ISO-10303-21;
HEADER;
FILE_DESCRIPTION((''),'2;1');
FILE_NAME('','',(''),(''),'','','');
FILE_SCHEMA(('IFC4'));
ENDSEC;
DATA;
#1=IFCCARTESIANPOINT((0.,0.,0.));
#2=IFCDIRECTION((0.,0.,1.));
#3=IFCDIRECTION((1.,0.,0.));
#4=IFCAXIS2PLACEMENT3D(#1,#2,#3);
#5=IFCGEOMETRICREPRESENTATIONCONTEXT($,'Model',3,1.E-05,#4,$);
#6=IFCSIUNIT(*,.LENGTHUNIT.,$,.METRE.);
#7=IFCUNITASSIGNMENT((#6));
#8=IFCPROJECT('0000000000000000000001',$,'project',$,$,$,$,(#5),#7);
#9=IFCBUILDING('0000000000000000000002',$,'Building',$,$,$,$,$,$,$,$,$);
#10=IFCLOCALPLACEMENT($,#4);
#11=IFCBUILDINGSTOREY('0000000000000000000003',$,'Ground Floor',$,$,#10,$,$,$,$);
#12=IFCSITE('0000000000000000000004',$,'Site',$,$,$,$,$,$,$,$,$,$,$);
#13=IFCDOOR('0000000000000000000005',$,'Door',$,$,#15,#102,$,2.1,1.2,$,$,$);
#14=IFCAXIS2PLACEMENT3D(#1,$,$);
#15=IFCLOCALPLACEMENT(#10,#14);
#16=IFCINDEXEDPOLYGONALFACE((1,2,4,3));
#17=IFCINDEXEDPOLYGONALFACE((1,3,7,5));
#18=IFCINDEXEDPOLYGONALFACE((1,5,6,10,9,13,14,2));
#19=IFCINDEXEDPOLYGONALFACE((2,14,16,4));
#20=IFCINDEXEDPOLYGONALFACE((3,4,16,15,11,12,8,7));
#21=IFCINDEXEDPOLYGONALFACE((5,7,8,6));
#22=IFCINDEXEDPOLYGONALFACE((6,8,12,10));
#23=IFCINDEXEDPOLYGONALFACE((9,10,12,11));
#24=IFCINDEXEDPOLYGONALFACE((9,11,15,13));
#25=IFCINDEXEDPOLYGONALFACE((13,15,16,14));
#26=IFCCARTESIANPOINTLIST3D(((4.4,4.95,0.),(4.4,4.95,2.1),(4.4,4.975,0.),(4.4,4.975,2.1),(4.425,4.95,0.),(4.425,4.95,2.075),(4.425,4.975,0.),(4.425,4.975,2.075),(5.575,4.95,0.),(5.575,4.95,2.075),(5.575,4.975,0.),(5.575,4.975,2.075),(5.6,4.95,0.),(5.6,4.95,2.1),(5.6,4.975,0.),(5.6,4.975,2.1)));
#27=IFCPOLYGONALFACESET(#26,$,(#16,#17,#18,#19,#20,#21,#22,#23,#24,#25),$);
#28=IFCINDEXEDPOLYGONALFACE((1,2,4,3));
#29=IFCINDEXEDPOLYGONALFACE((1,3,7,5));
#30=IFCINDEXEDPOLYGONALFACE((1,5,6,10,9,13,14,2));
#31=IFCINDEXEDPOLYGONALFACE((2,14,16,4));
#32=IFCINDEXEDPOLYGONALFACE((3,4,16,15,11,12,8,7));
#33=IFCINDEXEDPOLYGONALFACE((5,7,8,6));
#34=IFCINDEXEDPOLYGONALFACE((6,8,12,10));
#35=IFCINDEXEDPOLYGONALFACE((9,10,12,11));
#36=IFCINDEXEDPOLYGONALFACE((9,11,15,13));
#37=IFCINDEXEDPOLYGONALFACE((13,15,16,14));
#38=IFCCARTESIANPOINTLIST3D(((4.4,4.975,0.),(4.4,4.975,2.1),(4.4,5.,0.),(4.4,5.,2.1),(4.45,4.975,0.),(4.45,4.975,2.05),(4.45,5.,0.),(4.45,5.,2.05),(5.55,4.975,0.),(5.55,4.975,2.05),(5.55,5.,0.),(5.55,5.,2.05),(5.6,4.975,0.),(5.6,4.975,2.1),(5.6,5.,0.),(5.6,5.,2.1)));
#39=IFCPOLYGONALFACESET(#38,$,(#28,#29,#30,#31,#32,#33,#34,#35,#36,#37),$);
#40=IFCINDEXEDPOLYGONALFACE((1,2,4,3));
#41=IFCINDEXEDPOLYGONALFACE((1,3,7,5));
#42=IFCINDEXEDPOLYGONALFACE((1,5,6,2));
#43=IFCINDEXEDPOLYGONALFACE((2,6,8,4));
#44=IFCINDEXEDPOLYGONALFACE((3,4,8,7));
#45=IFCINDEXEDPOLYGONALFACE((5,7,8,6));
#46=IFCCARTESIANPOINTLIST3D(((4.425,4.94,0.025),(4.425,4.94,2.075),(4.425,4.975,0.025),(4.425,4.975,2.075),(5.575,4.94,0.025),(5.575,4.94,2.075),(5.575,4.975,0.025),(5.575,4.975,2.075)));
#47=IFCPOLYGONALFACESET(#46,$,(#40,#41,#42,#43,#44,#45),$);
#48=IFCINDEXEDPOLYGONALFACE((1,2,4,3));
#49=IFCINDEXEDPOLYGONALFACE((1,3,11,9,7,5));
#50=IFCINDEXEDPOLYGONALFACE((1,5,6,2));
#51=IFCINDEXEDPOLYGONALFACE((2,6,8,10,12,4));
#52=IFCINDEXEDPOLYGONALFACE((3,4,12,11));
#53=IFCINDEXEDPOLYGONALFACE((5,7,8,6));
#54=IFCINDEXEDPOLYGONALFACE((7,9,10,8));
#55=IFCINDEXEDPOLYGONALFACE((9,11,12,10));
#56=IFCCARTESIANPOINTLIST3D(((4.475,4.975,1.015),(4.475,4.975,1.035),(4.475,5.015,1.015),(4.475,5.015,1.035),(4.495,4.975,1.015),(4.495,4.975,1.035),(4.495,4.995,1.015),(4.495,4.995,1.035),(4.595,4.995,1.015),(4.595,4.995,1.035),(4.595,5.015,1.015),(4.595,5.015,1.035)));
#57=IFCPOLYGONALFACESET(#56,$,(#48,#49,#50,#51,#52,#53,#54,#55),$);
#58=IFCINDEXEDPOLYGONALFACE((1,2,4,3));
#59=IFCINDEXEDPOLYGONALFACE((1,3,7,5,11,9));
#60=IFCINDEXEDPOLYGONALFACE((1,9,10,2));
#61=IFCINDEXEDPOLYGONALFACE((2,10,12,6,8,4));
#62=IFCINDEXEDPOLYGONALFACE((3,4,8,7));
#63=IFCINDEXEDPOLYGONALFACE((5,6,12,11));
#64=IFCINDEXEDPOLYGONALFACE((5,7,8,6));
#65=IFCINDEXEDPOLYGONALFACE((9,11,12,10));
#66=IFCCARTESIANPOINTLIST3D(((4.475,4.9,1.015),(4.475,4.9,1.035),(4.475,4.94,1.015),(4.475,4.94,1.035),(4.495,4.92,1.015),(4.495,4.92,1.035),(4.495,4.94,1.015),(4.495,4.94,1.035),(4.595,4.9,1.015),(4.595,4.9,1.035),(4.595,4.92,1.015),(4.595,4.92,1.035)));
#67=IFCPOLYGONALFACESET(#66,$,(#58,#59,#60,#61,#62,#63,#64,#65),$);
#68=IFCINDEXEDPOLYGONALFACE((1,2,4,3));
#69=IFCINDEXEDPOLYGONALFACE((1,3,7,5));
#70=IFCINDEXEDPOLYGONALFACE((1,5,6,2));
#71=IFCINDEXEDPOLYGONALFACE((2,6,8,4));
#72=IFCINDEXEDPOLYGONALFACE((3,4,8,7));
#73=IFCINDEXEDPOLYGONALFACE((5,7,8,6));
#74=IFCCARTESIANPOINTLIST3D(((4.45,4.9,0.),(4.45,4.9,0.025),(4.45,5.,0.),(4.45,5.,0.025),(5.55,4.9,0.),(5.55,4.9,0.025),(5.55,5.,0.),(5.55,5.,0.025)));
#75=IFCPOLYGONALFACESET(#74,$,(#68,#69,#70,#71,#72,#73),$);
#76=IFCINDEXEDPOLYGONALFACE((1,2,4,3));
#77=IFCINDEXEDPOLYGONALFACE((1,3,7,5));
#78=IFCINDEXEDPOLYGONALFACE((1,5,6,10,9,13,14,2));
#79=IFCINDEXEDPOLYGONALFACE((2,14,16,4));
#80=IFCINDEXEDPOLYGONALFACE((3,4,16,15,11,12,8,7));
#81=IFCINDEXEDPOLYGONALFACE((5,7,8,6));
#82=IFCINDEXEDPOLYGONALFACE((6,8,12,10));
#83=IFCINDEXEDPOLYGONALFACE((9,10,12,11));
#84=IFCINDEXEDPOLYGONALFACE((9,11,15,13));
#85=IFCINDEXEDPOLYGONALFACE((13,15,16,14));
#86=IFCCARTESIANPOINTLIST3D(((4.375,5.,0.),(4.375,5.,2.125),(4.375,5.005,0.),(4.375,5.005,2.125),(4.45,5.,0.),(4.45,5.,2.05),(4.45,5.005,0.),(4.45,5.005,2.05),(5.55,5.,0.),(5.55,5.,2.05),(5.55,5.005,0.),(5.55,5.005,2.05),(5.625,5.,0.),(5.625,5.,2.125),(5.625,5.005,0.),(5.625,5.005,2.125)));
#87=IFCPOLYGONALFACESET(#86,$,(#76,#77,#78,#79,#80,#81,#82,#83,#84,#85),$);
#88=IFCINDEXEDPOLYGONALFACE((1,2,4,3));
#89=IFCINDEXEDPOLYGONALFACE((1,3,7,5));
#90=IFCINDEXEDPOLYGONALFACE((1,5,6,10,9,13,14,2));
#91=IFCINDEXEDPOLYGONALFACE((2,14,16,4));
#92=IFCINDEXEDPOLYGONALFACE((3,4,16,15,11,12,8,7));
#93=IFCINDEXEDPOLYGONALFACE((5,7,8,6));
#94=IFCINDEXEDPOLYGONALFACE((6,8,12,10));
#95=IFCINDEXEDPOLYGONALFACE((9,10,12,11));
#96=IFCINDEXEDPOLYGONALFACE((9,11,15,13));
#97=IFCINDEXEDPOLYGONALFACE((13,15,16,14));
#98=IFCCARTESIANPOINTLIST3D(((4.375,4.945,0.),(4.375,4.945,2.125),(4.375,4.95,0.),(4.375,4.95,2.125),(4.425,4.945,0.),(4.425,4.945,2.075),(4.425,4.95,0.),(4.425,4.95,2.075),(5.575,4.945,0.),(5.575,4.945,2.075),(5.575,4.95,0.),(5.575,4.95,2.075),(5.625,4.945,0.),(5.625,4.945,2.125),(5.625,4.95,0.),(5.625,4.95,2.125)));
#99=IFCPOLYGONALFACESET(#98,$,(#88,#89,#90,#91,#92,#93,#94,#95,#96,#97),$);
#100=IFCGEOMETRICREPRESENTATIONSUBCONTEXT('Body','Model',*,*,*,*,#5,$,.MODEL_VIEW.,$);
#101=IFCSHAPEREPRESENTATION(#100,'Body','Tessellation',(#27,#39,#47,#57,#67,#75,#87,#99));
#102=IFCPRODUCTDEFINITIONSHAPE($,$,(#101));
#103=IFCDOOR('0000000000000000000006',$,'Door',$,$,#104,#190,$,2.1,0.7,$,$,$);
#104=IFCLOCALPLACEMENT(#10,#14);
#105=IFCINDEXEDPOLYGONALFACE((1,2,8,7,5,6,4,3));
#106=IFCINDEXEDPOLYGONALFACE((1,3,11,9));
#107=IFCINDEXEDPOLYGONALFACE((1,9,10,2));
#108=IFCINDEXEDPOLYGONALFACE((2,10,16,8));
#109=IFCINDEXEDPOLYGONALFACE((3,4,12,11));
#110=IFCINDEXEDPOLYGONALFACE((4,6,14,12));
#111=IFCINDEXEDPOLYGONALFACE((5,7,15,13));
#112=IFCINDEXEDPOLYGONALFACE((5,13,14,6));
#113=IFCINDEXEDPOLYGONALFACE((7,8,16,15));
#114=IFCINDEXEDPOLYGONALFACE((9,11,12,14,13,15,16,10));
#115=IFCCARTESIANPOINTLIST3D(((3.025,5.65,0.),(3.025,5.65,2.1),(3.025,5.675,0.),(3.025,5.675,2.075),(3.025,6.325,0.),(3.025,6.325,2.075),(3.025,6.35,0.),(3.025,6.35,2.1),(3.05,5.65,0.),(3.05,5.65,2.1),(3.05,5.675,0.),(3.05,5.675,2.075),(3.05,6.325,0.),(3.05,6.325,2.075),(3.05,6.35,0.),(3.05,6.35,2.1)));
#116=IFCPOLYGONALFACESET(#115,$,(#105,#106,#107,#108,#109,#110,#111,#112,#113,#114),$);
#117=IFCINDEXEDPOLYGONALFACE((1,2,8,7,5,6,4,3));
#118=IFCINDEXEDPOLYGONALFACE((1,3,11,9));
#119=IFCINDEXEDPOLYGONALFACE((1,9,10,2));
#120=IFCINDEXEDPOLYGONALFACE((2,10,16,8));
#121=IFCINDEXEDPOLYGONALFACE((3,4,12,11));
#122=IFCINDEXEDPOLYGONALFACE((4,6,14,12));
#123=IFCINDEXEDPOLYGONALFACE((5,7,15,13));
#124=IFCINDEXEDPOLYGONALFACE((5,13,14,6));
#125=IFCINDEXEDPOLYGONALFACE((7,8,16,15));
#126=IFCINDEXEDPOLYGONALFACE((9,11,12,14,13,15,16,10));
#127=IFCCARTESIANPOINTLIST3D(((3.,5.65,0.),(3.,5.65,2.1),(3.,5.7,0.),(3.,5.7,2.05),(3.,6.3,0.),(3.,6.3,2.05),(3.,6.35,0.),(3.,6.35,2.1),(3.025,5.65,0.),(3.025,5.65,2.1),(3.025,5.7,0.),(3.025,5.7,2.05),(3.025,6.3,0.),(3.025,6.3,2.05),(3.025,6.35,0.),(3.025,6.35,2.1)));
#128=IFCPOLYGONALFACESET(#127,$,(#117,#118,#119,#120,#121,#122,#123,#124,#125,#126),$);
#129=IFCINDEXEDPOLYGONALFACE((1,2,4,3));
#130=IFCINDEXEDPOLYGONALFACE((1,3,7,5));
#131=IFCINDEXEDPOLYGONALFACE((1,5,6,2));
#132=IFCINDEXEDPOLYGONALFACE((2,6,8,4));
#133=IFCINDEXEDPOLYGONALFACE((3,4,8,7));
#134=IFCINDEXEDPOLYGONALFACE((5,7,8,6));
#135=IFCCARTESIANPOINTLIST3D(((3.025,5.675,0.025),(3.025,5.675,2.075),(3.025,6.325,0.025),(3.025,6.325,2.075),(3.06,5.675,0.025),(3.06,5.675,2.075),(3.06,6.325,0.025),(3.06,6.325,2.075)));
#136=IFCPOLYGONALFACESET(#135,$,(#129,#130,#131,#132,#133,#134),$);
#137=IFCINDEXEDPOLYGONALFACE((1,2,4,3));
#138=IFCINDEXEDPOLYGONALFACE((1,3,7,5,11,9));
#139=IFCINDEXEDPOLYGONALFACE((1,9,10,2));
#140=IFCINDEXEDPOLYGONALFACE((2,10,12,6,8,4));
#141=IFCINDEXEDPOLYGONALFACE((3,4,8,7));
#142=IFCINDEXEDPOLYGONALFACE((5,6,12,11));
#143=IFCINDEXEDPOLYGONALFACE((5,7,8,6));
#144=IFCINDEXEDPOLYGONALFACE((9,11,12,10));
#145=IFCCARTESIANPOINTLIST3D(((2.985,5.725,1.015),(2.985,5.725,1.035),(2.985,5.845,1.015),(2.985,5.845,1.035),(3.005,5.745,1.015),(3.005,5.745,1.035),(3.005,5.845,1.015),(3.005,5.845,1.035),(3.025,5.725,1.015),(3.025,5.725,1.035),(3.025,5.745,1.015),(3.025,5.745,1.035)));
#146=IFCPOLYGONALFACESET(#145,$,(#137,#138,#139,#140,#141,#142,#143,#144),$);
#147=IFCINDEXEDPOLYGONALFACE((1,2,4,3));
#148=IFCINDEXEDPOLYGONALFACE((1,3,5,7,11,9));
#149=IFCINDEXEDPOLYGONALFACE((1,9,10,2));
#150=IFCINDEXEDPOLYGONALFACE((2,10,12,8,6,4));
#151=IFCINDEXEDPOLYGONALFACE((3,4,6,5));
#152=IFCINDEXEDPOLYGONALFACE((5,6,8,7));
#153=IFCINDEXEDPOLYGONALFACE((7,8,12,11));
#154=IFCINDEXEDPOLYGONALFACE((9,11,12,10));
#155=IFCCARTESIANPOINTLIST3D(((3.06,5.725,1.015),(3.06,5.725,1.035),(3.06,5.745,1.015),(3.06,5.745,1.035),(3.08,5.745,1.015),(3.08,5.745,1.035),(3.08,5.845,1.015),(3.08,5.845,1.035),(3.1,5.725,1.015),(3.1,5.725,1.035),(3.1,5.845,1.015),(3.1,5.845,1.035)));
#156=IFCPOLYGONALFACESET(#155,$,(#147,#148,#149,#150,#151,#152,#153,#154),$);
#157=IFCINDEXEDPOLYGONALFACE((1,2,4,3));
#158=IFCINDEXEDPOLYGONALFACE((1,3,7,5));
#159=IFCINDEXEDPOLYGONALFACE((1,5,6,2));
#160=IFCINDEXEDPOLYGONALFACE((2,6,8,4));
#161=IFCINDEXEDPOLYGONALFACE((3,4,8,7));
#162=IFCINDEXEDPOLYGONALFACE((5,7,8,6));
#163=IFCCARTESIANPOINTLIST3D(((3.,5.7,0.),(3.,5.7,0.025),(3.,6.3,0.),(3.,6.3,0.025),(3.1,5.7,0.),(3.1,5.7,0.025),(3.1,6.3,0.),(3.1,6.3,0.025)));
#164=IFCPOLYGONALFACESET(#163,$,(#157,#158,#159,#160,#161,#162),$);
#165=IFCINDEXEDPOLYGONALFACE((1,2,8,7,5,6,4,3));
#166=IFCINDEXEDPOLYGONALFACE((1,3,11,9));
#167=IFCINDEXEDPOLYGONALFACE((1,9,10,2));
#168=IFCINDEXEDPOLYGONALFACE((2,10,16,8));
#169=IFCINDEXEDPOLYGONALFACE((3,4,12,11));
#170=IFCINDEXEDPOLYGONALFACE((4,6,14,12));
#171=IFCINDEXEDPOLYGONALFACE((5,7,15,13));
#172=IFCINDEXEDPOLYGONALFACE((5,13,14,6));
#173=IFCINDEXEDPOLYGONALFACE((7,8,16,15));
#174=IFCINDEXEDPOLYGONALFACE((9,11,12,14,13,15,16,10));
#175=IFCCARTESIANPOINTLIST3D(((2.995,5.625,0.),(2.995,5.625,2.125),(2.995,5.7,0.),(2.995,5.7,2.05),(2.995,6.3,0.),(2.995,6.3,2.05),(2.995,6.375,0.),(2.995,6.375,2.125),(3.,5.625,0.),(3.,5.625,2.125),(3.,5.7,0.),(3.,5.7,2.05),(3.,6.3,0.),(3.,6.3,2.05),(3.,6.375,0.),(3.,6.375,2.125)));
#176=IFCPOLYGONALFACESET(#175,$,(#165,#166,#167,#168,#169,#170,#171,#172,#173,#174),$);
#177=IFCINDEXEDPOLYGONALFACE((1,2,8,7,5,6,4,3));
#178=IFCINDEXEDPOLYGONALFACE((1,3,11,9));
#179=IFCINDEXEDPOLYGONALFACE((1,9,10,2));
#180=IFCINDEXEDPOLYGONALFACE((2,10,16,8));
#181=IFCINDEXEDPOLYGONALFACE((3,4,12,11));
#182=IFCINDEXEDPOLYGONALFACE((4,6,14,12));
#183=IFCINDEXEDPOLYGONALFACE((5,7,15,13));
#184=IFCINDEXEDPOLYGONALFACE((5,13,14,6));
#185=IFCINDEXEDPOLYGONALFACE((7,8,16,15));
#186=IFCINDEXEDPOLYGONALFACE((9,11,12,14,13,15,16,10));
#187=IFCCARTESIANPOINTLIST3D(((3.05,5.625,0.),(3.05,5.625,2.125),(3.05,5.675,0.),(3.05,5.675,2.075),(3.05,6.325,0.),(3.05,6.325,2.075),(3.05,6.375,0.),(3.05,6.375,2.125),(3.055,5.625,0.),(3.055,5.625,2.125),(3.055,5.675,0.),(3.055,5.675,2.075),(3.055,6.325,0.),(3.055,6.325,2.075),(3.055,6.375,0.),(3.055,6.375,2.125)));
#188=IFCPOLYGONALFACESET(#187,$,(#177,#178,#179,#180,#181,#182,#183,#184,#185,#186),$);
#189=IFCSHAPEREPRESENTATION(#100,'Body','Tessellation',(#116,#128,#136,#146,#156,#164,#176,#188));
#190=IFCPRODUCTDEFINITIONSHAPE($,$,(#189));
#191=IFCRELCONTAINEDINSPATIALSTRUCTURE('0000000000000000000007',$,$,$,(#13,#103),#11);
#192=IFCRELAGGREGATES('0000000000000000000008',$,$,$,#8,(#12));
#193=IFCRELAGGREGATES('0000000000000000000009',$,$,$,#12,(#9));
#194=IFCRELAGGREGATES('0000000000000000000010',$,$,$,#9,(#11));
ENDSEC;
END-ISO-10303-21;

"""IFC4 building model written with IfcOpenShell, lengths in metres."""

from ifc_helpers import new_model, si_unit, frame, origin_with_axes, place, context, subcontext, project, spatial, line, indexed_curve, outline, extrude, element, save


model = new_model("IFC4")

# Units and contexts
model_context = context("Model", 3, precision=1e-05, world=origin_with_axes())
body_context = subcontext(model_context, "Body", "Model", "MODEL_VIEW")
ifc_project = project(units=[si_unit("LENGTHUNIT", "METRE")], contexts=[model_context])

# Site, building, storey
site = spatial("IfcSite", under=ifc_project, Name="Site")
building = spatial("IfcBuilding", under=site, Name="Building")
storey_placement = place(None, origin_with_axes())
storey = spatial("IfcBuildingStorey", under=building, at=storey_placement, Name="Ground Floor")

# Doors
door_1_placement = place(storey_placement, frame((5.6, 5.0, 0.0), z_axis=(0.0, 0.0, 1.0), x_axis=(-1.0, 0.0, 0.0)))
element("IfcDoor", 1, at=door_1_placement, inside=storey, Name="Door", OverallHeight=2.1, OverallWidth=1.2, context=body_context, shape_type="SweptSolid", body=[
    extrude(outline(indexed_curve([(0.0, 0.0), (0.0, 2.1), (1.2, 2.1), (1.2, 0.0), (1.175, 0.0), (1.175, 2.075), (0.025, 2.075), (0.025, 0.0)], segments=[line(1, 2, 3, 4, 5, 6, 7, 8, 1)])), frame((0.0, 0.025, 0.0), z_axis=(0.0, -1.0, 0.0), x_axis=(1.0, 0.0, 0.0)), (0.0, 0.0, -1.0), 0.025),
    extrude(outline(indexed_curve([(0.0, 0.0), (0.0, 2.1), (1.2, 2.1), (1.2, 0.0), (1.15, 0.0), (1.15, 2.05), (0.05, 2.05), (0.05, 0.0)], segments=[line(1, 2, 3, 4, 5, 6, 7, 8, 1)])), frame((0.0, 0.0, 0.0), z_axis=(0.0, -1.0, 0.0), x_axis=(1.0, 0.0, 0.0)), (0.0, 0.0, -1.0), 0.025),
    extrude(outline(indexed_curve([(0.0, 0.0), (1.15, 0.0), (1.15, 0.035), (0.0, 0.035)], segments=[line(1, 2, 3, 4, 1)])), frame((0.025, 0.025, 0.025), z_axis=(0.0, 0.0, 1.0), x_axis=(1.0, 0.0, 0.0)), (0.0, 0.0, 1.0), 2.05),
    extrude(outline(indexed_curve([(0.0, 0.0), (0.0, -0.04), (-0.12, -0.04), (-0.12, -0.02), (-0.02, -0.02), (-0.02, 0.0)], segments=[line(1, 2, 3, 4, 5, 6, 1)])), frame((1.125, 0.025, 1.015), z_axis=(0.0, 0.0, 1.0), x_axis=(1.0, 0.0, 0.0)), (0.0, 0.0, 1.0), 0.02),
    extrude(outline(indexed_curve([(0.0, 0.0), (0.0, 0.04), (-0.12, 0.04), (-0.12, 0.02), (-0.02, 0.02), (-0.02, 0.0)], segments=[line(1, 2, 3, 4, 5, 6, 1)])), frame((1.125, 0.06, 1.015), z_axis=(0.0, 0.0, 1.0), x_axis=(1.0, 0.0, 0.0)), (0.0, 0.0, 1.0), 0.02),
    extrude(outline(indexed_curve([(0.0, 0.0), (1.1, 0.0), (1.1, 0.1), (0.0, 0.1)], segments=[line(1, 2, 3, 4, 1)])), frame((0.05, 0.0, 0.0), z_axis=(0.0, 0.0, 1.0), x_axis=(1.0, 0.0, 0.0)), (0.0, 0.0, 1.0), 0.025),
    extrude(outline(indexed_curve([(0.0, 0.0), (0.0, 2.125), (1.25, 2.125), (1.25, 0.0), (1.175, 0.0), (1.175, 2.05), (0.075, 2.05), (0.075, 0.0)], segments=[line(1, 2, 3, 4, 5, 6, 7, 8, 1)])), frame((-0.025, -0.005, 0.0), z_axis=(0.0, -1.0, 0.0), x_axis=(1.0, 0.0, 0.0)), (0.0, 0.0, -1.0), 0.005),
    extrude(outline(indexed_curve([(0.0, 0.0), (0.0, 2.125), (1.25, 2.125), (1.25, 0.0), (1.2, 0.0), (1.2, 2.075), (0.05, 2.075), (0.05, 0.0)], segments=[line(1, 2, 3, 4, 5, 6, 7, 8, 1)])), frame((-0.025, 0.05, 0.0), z_axis=(0.0, -1.0, 0.0), x_axis=(1.0, 0.0, 0.0)), (0.0, 0.0, -1.0), 0.005),
])
door_2_placement = place(storey_placement, frame((3.0, 6.35, 0.0), z_axis=(0.0, 0.0, 1.0), x_axis=(0.0, -1.0, 0.0)))
element("IfcDoor", 2, at=door_2_placement, inside=storey, Name="Door", OverallHeight=2.1, OverallWidth=0.7, context=body_context, shape_type="SweptSolid", body=[
    extrude(outline(indexed_curve([(0.0, 0.0), (0.0, 2.1), (0.7, 2.1), (0.7, 0.0), (0.675, 0.0), (0.675, 2.075), (0.025, 2.075), (0.025, 0.0)], segments=[line(1, 2, 3, 4, 5, 6, 7, 8, 1)])), frame((0.0, 0.025, 0.0), z_axis=(0.0, -1.0, 0.0), x_axis=(1.0, 0.0, 0.0)), (0.0, 0.0, -1.0), 0.025),
    extrude(outline(indexed_curve([(0.0, 0.0), (0.0, 2.1), (0.7, 2.1), (0.7, 0.0), (0.65, 0.0), (0.65, 2.05), (0.05, 2.05), (0.05, 0.0)], segments=[line(1, 2, 3, 4, 5, 6, 7, 8, 1)])), frame((0.0, 0.0, 0.0), z_axis=(0.0, -1.0, 0.0), x_axis=(1.0, 0.0, 0.0)), (0.0, 0.0, -1.0), 0.025),
    extrude(outline(indexed_curve([(0.0, 0.0), (0.65, 0.0), (0.65, 0.035), (0.0, 0.035)], segments=[line(1, 2, 3, 4, 1)])), frame((0.025, 0.025, 0.025), z_axis=(0.0, 0.0, 1.0), x_axis=(1.0, 0.0, 0.0)), (0.0, 0.0, 1.0), 2.05),
    extrude(outline(indexed_curve([(0.0, 0.0), (0.0, -0.04), (-0.12, -0.04), (-0.12, -0.02), (-0.02, -0.02), (-0.02, 0.0)], segments=[line(1, 2, 3, 4, 5, 6, 1)])), frame((0.625, 0.025, 1.015), z_axis=(0.0, 0.0, 1.0), x_axis=(1.0, 0.0, 0.0)), (0.0, 0.0, 1.0), 0.02),
    extrude(outline(indexed_curve([(0.0, 0.0), (0.0, 0.04), (-0.12, 0.04), (-0.12, 0.02), (-0.02, 0.02), (-0.02, 0.0)], segments=[line(1, 2, 3, 4, 5, 6, 1)])), frame((0.625, 0.06, 1.015), z_axis=(0.0, 0.0, 1.0), x_axis=(1.0, 0.0, 0.0)), (0.0, 0.0, 1.0), 0.02),
    extrude(outline(indexed_curve([(0.0, 0.0), (0.6, 0.0), (0.6, 0.1), (0.0, 0.1)], segments=[line(1, 2, 3, 4, 1)])), frame((0.05, 0.0, 0.0), z_axis=(0.0, 0.0, 1.0), x_axis=(1.0, 0.0, 0.0)), (0.0, 0.0, 1.0), 0.025),
    extrude(outline(indexed_curve([(0.0, 0.0), (0.0, 2.125), (0.75, 2.125), (0.75, 0.0), (0.675, 0.0), (0.675, 2.05), (0.075, 2.05), (0.075, 0.0)], segments=[line(1, 2, 3, 4, 5, 6, 7, 8, 1)])), frame((-0.025, -0.005, 0.0), z_axis=(0.0, -1.0, 0.0), x_axis=(1.0, 0.0, 0.0)), (0.0, 0.0, -1.0), 0.005),
    extrude(outline(indexed_curve([(0.0, 0.0), (0.0, 2.125), (0.75, 2.125), (0.75, 0.0), (0.7, 0.0), (0.7, 2.075), (0.05, 2.075), (0.05, 0.0)], segments=[line(1, 2, 3, 4, 5, 6, 7, 8, 1)])), frame((-0.025, 0.05, 0.0), z_axis=(0.0, -1.0, 0.0), x_axis=(1.0, 0.0, 0.0)), (0.0, 0.0, -1.0), 0.005),
])

save(model, "model.ifc")
